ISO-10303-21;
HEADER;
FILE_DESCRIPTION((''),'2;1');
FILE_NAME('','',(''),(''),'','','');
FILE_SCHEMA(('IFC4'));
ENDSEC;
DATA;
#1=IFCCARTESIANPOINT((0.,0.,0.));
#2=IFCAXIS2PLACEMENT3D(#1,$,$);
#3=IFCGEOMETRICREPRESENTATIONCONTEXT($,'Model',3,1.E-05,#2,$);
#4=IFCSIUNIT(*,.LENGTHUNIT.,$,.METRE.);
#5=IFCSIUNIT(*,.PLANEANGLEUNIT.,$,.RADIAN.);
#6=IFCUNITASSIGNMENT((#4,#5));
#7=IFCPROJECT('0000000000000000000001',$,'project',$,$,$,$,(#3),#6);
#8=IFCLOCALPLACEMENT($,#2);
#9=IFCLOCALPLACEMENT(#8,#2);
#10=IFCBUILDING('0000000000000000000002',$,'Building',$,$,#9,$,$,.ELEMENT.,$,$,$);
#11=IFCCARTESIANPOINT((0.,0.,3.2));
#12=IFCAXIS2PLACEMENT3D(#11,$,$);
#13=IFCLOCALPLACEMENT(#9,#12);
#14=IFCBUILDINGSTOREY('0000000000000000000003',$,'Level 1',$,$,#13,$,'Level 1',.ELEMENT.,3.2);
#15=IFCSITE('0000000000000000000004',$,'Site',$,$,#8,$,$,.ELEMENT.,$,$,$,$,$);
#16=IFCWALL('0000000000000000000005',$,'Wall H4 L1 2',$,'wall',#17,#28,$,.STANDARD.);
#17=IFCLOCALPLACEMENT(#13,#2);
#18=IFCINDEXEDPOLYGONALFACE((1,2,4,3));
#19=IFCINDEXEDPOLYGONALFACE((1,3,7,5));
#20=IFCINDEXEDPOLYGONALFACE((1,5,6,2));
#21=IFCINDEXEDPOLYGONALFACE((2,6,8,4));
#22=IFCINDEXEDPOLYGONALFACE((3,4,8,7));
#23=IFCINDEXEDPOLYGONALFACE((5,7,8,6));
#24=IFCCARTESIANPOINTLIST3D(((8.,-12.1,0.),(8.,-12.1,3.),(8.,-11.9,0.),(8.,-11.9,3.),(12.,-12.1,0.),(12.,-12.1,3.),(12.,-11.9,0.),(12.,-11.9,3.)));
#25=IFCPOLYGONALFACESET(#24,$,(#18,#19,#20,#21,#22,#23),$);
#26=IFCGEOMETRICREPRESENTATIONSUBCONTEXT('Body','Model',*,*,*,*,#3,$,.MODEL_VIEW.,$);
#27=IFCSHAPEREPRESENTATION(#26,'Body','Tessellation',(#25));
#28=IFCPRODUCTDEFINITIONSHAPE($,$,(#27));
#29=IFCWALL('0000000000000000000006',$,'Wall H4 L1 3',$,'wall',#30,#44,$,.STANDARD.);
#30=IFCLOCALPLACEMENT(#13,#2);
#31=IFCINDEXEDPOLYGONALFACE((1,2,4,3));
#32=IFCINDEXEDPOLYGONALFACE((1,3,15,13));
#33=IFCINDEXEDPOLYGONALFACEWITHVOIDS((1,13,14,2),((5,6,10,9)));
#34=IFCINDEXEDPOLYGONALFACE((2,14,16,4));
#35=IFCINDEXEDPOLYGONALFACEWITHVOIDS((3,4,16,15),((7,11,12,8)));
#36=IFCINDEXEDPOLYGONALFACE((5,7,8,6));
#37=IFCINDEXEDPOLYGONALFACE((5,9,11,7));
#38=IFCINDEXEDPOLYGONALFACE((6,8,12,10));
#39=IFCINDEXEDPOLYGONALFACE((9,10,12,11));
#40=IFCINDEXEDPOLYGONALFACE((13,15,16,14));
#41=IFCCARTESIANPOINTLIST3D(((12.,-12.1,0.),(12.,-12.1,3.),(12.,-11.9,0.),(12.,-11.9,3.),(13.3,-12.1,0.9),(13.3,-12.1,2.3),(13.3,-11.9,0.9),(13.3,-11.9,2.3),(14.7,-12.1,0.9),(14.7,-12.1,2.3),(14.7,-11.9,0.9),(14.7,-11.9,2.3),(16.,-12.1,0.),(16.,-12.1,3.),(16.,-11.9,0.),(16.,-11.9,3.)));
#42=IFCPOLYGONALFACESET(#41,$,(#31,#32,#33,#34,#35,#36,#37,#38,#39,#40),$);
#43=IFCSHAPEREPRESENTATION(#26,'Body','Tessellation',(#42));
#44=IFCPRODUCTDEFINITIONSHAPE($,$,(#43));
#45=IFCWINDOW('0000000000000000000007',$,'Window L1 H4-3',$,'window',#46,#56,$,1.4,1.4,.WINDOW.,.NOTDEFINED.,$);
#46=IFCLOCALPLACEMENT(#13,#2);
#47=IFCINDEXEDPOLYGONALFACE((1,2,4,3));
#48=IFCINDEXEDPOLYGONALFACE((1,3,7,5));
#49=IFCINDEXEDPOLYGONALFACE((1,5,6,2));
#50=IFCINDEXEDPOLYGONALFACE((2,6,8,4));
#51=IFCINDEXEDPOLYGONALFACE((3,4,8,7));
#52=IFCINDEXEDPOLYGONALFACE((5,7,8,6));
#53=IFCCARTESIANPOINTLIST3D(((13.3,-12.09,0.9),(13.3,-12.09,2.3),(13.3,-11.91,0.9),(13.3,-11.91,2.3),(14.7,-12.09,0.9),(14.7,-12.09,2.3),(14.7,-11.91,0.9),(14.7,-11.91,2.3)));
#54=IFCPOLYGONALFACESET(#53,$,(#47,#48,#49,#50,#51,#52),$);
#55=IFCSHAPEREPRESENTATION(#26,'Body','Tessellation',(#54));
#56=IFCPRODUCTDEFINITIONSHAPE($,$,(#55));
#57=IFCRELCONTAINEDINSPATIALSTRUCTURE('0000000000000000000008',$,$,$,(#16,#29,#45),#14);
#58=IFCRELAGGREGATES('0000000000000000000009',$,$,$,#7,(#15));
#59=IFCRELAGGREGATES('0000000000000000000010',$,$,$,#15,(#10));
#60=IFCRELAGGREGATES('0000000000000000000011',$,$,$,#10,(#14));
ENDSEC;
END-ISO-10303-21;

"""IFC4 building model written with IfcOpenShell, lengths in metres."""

from ifc_helpers import new_model, si_unit, frame, frame_2d, origin, origin_2d, place, context, subcontext, project, spatial, rectangle, extrude, element, fill, save


model = new_model("IFC4")

# Units and contexts
model_context = context("Model", 3, precision=1e-05, world=origin())
body_context = subcontext(model_context, "Body", "Model", "MODEL_VIEW")
ifc_project = project(units=[si_unit("LENGTHUNIT", "METRE"), si_unit("PLANEANGLEUNIT", "RADIAN")], contexts=[model_context])

# Site, building, storey
site_placement = place(None, origin())
site = spatial("IfcSite", under=ifc_project, at=site_placement, Name="Site", CompositionType="ELEMENT")
building_placement = place(site_placement, origin())
building = spatial("IfcBuilding", under=site, at=building_placement, Name="Building", CompositionType="ELEMENT")
storey_placement = place(building_placement, frame((0.0, 0.0, 3.2)))
storey = spatial("IfcBuildingStorey", under=building, at=storey_placement, Name="Level 1", LongName="Level 1", CompositionType="ELEMENT", Elevation=3.2)

# Wall
for number, where, z_axis, x_axis, name in (
    (1, (8.0, -12.0, 0.0), (0.0, 0.0, 1.0), (1.0, 0.0, 0.0), "Wall H4 L1 2"),
):
    element("IfcWall", number, at=place(storey_placement, frame(where, z_axis=z_axis, x_axis=x_axis)), inside=storey, Name=name, ObjectType="wall", PredefinedType="STANDARD", context=body_context, shape_type="SweptSolid", body=[
        extrude(rectangle(XDim=4.0, YDim=0.2, at=frame_2d((2.0, 0.0))), origin(), (0.0, 0.0, 1.0), 3.0),
    ])

# Wall, opening, window
wall_1_placement = place(storey_placement, frame((12.0, -12.0, 0.0), z_axis=(0.0, 0.0, 1.0), x_axis=(1.0, 0.0, 0.0)))
wall_1 = element("IfcWall", 2, at=wall_1_placement, inside=storey, Name="Wall H4 L1 3", ObjectType="wall", PredefinedType="STANDARD", context=body_context, shape_type="SweptSolid", body=[
    extrude(rectangle(XDim=4.0, YDim=0.2, at=frame_2d((2.0, 0.0))), origin(), (0.0, 0.0, 1.0), 3.0),
])
opening_1_placement = place(storey_placement, frame((14.0, -12.0, 0.9), z_axis=(0.0, 0.0, 1.0), x_axis=(1.0, 0.0, 0.0)))
opening_1 = element("IfcOpeningElement", 3, at=opening_1_placement, cuts=wall_1, ObjectType="Opening", PredefinedType="OPENING", context=body_context, shape_type="SweptSolid", body=[
    extrude(rectangle(XDim=1.4, YDim=0.22, at=origin_2d()), origin(), (0.0, 0.0, 1.0), 1.4),
])
window_1_placement = place(storey_placement, frame((14.0, -12.0, 0.9), z_axis=(0.0, 0.0, 1.0), x_axis=(1.0, 0.0, 0.0)))
window_1 = element("IfcWindow", 4, at=window_1_placement, inside=storey, Name="Window L1 H4-3", ObjectType="window", OverallHeight=1.4, OverallWidth=1.4, PartitioningType="NOTDEFINED", PredefinedType="WINDOW", context=body_context, shape_type="SweptSolid", body=[
    extrude(rectangle(XDim=1.4, YDim=0.18, at=origin_2d()), origin(), (0.0, 0.0, 1.0), 1.4),
])
fill(opening_1, window_1)

save(model, "model.ifc")
